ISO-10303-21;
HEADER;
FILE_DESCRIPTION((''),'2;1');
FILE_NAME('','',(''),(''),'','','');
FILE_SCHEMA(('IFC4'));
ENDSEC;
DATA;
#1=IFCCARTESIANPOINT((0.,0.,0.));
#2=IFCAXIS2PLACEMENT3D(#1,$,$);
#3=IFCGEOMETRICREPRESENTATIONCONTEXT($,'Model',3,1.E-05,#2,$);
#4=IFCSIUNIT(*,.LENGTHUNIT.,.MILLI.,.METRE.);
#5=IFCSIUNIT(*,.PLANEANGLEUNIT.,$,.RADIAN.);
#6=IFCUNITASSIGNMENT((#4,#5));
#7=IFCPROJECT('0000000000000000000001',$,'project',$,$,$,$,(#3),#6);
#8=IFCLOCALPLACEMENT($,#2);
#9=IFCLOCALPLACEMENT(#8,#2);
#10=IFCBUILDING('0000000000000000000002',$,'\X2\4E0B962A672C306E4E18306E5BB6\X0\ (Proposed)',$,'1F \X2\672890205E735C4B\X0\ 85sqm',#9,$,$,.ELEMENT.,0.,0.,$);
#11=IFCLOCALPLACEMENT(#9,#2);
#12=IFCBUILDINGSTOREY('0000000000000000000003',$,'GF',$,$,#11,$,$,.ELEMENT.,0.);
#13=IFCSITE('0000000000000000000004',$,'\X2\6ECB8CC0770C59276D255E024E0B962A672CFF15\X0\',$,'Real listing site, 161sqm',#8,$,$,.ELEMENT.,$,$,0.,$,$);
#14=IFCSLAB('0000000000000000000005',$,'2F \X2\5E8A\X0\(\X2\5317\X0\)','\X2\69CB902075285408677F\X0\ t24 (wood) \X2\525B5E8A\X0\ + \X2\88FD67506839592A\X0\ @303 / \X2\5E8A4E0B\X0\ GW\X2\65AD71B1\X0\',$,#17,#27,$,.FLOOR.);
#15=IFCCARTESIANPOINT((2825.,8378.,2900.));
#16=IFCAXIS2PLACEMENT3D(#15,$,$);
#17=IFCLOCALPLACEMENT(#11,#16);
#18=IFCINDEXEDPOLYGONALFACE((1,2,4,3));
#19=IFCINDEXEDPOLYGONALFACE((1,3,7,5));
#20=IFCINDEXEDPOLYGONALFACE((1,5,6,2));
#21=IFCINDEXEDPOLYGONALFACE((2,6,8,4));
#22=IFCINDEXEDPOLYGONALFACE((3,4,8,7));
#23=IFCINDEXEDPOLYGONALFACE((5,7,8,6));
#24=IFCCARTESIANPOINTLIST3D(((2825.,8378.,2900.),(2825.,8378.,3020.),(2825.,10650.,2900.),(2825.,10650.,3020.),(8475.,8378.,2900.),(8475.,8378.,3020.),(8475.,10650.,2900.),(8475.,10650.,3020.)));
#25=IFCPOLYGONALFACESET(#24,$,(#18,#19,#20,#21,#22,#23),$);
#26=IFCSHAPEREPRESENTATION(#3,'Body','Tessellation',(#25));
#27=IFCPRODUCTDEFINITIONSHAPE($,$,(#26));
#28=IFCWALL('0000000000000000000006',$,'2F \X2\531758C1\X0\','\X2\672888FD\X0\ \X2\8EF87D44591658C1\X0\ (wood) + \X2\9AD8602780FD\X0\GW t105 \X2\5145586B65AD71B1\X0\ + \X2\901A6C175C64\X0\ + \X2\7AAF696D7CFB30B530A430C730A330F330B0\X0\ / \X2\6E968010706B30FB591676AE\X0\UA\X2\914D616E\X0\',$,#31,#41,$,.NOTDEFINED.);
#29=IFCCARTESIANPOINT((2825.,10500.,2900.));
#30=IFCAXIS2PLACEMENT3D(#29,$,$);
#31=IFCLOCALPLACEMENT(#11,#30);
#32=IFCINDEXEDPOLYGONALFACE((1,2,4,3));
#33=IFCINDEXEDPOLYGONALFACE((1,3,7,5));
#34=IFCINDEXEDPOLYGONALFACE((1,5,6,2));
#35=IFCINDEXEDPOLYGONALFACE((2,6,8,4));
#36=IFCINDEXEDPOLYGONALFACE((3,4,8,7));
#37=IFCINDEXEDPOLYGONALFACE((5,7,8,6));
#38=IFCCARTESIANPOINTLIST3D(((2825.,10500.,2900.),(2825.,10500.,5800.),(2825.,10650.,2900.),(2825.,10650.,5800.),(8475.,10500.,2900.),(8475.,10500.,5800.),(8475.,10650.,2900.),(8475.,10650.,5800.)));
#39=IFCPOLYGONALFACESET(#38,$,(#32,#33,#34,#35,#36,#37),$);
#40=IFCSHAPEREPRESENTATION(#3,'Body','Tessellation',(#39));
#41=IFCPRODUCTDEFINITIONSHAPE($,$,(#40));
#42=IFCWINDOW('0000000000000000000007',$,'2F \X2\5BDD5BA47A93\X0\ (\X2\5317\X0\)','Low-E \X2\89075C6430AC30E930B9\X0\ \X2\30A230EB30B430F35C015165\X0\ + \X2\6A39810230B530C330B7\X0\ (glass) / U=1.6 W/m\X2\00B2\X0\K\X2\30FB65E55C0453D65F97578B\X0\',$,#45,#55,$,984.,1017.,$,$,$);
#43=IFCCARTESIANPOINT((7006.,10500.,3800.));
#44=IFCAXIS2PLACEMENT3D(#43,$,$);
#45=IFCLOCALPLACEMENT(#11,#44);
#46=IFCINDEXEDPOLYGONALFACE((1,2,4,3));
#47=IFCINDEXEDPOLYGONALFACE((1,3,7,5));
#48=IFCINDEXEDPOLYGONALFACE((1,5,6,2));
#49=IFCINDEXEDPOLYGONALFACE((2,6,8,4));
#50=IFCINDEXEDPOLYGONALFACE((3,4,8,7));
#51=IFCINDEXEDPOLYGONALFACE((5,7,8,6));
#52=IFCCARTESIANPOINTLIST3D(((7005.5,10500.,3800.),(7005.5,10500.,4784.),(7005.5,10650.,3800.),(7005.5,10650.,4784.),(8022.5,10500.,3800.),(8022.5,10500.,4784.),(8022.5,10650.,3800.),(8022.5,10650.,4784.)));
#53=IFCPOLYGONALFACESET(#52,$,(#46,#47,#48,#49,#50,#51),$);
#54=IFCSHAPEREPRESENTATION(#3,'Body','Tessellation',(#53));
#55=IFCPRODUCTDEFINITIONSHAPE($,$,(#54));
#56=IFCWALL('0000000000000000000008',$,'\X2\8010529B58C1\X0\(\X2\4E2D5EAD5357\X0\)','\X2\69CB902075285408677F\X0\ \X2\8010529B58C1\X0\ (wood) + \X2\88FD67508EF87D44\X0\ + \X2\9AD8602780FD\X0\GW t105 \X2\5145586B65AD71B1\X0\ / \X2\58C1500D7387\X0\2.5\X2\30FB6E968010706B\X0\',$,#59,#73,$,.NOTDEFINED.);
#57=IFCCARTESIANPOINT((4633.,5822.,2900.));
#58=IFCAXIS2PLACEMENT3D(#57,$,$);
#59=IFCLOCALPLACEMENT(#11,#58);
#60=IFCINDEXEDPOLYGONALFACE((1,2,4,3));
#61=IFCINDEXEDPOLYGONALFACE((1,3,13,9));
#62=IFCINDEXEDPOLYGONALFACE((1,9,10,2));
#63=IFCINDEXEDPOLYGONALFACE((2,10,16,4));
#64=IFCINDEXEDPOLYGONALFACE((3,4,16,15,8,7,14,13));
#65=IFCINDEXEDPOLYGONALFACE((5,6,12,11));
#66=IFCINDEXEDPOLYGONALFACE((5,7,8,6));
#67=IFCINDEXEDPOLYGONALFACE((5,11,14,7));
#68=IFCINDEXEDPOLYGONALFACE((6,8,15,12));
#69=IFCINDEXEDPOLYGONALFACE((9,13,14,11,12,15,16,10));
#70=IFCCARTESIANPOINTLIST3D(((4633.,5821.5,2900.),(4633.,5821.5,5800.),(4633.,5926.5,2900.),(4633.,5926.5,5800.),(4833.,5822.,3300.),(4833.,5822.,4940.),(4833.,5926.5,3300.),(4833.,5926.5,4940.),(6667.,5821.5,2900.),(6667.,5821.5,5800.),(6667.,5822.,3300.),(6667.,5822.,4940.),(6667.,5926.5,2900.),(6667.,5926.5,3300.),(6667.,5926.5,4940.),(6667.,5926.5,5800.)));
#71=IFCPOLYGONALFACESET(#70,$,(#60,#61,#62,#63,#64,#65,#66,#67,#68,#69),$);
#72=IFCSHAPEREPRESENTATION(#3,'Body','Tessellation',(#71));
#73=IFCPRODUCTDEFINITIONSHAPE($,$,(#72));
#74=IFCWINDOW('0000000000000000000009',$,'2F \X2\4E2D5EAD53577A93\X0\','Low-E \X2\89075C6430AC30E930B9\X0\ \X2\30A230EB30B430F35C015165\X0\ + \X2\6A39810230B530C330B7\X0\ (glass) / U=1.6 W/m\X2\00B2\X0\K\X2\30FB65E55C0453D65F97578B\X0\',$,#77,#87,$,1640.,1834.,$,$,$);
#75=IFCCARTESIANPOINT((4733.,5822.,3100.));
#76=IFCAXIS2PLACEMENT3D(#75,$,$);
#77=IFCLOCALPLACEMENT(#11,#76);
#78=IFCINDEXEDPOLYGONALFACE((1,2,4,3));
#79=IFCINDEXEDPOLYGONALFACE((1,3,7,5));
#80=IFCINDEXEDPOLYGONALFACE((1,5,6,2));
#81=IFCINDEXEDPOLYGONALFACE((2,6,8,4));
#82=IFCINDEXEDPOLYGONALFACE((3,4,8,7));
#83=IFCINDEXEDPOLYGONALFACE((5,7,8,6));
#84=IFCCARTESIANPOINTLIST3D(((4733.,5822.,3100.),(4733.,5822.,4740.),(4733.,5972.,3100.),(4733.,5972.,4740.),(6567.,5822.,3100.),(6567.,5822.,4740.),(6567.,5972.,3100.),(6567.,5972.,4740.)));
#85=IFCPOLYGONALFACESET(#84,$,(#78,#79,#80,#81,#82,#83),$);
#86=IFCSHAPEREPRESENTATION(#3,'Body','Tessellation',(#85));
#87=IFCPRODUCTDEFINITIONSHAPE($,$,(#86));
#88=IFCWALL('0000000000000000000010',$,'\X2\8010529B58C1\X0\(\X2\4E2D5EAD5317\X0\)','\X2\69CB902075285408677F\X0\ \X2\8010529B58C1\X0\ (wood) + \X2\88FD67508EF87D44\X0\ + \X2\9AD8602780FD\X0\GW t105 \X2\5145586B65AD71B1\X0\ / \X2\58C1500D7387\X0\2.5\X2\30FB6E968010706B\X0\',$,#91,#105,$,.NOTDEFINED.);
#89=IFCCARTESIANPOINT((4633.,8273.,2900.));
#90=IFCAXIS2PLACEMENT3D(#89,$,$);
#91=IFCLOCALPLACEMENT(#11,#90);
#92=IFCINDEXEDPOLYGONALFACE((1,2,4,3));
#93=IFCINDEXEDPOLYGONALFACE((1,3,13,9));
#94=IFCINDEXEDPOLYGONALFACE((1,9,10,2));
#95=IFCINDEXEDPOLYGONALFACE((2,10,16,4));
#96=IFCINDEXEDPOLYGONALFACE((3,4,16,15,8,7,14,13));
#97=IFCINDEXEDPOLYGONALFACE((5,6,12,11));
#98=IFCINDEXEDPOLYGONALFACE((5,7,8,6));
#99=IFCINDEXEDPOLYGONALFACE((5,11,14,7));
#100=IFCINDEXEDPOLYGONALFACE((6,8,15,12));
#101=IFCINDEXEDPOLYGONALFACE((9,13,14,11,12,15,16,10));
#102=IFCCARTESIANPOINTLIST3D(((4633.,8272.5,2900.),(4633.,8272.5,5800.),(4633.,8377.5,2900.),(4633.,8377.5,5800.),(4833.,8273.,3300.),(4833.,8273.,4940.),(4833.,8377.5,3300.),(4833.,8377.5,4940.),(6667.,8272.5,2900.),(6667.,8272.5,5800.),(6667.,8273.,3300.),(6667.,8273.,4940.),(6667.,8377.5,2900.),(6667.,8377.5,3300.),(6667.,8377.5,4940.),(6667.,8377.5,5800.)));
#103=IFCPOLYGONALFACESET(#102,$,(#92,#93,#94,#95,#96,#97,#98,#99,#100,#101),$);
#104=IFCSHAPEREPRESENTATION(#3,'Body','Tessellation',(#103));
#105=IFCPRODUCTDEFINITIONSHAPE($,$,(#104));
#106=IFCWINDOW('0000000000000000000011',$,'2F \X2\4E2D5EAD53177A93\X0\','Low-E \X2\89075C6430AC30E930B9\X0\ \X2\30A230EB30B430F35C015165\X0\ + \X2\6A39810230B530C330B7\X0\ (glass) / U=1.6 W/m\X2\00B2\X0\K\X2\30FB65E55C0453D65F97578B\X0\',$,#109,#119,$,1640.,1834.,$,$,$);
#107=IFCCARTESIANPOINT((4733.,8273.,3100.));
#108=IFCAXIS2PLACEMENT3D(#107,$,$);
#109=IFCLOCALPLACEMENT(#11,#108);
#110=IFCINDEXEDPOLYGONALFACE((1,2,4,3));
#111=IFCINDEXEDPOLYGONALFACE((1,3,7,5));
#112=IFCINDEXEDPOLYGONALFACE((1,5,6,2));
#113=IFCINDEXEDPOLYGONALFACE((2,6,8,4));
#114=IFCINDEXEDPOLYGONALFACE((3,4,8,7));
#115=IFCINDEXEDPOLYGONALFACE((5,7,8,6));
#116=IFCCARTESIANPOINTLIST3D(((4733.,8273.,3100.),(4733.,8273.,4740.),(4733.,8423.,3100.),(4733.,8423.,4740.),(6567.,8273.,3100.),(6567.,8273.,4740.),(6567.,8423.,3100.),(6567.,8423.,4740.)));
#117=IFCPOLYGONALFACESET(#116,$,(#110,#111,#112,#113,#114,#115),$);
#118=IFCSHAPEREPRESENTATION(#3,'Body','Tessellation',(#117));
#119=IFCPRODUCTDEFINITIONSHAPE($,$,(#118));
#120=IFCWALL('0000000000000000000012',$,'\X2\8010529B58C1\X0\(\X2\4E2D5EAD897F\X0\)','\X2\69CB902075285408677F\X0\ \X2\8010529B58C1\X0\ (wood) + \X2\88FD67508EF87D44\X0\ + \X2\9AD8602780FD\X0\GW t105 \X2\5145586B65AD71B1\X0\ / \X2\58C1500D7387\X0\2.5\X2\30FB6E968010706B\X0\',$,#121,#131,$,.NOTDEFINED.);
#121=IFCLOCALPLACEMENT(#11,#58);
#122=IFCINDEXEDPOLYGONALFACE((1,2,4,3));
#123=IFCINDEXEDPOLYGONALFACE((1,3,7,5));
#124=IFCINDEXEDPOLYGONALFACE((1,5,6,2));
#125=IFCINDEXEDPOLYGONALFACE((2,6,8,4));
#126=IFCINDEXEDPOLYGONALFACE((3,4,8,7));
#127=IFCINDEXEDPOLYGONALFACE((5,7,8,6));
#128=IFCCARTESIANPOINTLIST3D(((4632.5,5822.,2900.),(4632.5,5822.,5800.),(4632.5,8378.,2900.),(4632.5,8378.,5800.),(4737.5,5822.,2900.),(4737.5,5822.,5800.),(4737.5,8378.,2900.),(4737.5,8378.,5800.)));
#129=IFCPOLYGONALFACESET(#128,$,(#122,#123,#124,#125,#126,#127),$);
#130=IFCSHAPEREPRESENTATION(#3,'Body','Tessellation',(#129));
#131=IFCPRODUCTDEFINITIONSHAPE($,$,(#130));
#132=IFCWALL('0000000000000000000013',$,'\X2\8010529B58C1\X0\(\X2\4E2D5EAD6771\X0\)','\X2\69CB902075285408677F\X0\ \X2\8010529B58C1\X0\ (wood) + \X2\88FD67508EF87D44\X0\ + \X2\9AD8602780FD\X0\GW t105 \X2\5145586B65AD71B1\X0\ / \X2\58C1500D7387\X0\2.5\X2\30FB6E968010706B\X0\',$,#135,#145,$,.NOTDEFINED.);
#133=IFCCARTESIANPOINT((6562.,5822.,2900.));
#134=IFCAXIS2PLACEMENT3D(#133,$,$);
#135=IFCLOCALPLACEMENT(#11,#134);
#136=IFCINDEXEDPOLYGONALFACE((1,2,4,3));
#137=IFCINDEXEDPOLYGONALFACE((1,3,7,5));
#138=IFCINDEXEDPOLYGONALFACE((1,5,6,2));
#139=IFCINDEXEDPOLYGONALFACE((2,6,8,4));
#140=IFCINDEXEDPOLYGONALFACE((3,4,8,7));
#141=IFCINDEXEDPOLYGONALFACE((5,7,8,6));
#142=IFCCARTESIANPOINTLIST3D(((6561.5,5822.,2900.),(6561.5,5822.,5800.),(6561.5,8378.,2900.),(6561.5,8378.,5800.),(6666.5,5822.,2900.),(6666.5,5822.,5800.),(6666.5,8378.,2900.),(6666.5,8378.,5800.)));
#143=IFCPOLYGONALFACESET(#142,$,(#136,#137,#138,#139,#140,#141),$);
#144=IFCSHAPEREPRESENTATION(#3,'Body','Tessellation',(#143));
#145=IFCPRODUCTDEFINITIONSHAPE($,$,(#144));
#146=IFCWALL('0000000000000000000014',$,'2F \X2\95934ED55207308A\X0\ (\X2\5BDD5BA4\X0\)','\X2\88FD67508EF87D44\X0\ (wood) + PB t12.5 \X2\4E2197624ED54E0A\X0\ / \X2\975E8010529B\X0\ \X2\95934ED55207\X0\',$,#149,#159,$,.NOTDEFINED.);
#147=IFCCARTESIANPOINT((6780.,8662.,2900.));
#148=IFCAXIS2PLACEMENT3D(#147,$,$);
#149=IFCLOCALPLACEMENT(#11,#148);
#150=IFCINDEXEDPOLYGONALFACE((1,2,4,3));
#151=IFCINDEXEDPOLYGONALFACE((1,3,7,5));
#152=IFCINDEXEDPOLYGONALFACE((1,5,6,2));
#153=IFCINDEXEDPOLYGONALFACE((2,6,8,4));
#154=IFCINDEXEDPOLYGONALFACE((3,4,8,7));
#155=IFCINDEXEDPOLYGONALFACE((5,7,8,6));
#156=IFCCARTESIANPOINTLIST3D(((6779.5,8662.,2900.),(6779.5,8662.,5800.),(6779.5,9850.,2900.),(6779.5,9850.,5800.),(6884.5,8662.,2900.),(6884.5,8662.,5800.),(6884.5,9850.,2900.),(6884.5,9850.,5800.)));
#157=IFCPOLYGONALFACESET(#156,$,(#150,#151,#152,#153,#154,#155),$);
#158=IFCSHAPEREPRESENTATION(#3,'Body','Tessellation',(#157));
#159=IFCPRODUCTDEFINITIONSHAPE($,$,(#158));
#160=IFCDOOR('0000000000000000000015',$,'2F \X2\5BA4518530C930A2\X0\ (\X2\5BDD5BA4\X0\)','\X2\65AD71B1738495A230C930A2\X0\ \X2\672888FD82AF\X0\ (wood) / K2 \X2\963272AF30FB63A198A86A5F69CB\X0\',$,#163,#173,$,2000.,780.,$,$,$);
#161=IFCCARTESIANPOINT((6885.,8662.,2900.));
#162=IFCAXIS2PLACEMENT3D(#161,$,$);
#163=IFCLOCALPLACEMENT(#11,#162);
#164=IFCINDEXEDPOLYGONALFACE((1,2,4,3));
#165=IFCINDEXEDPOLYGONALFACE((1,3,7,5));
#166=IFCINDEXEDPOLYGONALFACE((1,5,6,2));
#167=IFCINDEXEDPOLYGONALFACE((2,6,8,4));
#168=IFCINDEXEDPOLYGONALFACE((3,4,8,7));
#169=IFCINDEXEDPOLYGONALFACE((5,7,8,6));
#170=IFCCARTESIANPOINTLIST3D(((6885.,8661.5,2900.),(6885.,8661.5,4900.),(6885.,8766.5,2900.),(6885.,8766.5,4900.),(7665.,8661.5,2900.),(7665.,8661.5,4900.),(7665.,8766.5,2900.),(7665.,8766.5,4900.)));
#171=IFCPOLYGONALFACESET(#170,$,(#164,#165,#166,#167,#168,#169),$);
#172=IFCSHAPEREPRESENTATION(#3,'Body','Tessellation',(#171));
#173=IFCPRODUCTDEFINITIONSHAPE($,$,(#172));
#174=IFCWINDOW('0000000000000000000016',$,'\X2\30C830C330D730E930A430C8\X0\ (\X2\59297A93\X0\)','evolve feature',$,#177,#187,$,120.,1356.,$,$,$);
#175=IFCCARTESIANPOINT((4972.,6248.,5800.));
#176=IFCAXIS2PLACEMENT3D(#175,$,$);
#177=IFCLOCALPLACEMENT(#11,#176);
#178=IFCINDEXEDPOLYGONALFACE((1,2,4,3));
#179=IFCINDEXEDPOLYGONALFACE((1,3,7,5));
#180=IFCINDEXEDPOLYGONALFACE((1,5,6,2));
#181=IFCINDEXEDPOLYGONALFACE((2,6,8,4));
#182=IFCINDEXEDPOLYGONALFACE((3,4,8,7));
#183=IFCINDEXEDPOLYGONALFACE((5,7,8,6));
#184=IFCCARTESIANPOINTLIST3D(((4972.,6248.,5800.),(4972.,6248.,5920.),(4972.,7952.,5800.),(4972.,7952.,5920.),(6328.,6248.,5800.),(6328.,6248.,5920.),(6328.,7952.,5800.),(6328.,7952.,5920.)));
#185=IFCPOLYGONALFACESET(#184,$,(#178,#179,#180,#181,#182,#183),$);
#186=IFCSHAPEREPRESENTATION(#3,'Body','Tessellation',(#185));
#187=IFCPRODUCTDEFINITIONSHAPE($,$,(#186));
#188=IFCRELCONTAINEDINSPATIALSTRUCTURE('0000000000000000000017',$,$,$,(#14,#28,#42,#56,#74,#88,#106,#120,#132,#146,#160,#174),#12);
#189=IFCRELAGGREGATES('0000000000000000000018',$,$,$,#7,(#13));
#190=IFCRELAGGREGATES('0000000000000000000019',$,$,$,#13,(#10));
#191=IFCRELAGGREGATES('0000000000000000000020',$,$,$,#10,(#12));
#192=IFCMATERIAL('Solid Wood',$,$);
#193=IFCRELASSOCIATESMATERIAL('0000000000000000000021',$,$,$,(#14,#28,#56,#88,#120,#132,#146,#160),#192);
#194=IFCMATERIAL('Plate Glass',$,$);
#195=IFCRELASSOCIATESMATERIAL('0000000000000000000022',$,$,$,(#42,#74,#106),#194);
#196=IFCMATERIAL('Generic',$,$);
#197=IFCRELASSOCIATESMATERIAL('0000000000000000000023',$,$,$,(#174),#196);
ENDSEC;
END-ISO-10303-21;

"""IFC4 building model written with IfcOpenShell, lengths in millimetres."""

from ifc_helpers import new_model, si_unit, frame, frame_2d, origin, place, context, project, spatial, rectangle, extrude, material, element, fill, save


model = new_model("IFC4")

# Units and contexts
model_context = context("Model", 3, precision=1e-05, world=origin())
ifc_project = project(units=[si_unit("LENGTHUNIT", "METRE", prefix="MILLI"), si_unit("PLANEANGLEUNIT", "RADIAN")], contexts=[model_context])

# Site, building, storey
site_placement = place(None, origin())
site = spatial("IfcSite", under=ifc_project, at=site_placement, Name="滋賀県大津市下阪本５", ObjectType="Real listing site, 161sqm", CompositionType="ELEMENT", RefElevation=0.0)
building_placement = place(site_placement, origin())
building = spatial("IfcBuilding", under=site, at=building_placement, Name="下阪本の丘の家 (Proposed)", ObjectType="1F 木造平屋 85sqm", CompositionType="ELEMENT", ElevationOfRefHeight=0.0, ElevationOfTerrain=0.0)
storey_placement = place(building_placement, origin())
storey = spatial("IfcBuildingStorey", under=building, at=storey_placement, Name="GF", CompositionType="ELEMENT", Elevation=0.0)

# Slab
ifc_material_1 = material(Name="Solid Wood")
slab_placement = place(storey_placement, frame((2825.0, 8378.0, 2900.0)))
element("IfcSlab", 1, at=slab_placement, inside=storey, material=ifc_material_1, Name="2F 床(北)", Description="構造用合板 t24 (wood) 剛床 + 製材根太 @303 / 床下 GW断熱", PredefinedType="FLOOR", context=model_context, shape_type="SweptSolid", body=[
    extrude(rectangle(XDim=5650.0, YDim=2272.0, at=frame_2d((2825.0, 1136.0))), frame((2825.0, 8378.0, 2900.0)), (0.0, 0.0, 1.0), 120.0),
])

# Walls, openings, windows
wall_1_placement = place(storey_placement, frame((2825.0, 10500.0, 2900.0)))
wall_1 = element("IfcWall", 2, at=wall_1_placement, inside=storey, material=ifc_material_1, Name="2F 北壁", Description="木製 軸組外壁 (wood) + 高性能GW t105 充填断熱 + 通気層 + 窯業系サイディング / 準耐火・外皮UA配慮", PredefinedType="NOTDEFINED", context=model_context, shape_type="SweptSolid", body=[
    extrude(rectangle(XDim=5650.0, YDim=150.0, at=frame_2d((2825.0, 75.0))), frame((2825.0, 10500.0, 2900.0)), (0.0, 0.0, 1.0), 2900.0),
])
opening_1_placement = place(storey_placement, frame((7006.0, 10500.0, 3800.0)))
opening_1 = element("IfcOpeningElement", 3, at=opening_1_placement, cuts=wall_1, PredefinedType="NOTDEFINED", context=model_context, shape_type="SweptSolid", body=[
    extrude(rectangle(XDim=1017.0, YDim=150.0, at=frame_2d((508.0, 75.0))), frame((7006.0, 10500.0, 3800.0)), (0.0, 0.0, 1.0), 984.0),
])
ifc_material_2 = material(Name="Plate Glass")
window_1_placement = place(storey_placement, frame((7006.0, 10500.0, 3800.0)))
window_1 = element("IfcWindow", 4, at=window_1_placement, inside=storey, material=ifc_material_2, Name="2F 寝室窓 (北)", Description="Low-E 複層ガラス アルゴン封入 + 樹脂サッシ (glass) / U=1.6 W/m²K・日射取得型", OverallHeight=984.0, OverallWidth=1017.0, context=model_context, shape_type="SweptSolid", body=[
    extrude(rectangle(XDim=1017.0, YDim=150.0, at=frame_2d((508.0, 75.0))), frame((7006.0, 10500.0, 3800.0)), (0.0, 0.0, 1.0), 984.0),
])
fill(opening_1, window_1)
wall_2_placement = place(storey_placement, frame((4633.0, 5822.0, 2900.0)))
wall_2 = element("IfcWall", 5, at=wall_2_placement, inside=storey, material=ifc_material_1, Name="耐力壁(中庭南)", Description="構造用合板 耐力壁 (wood) + 製材軸組 + 高性能GW t105 充填断熱 / 壁倍率2.5・準耐火", PredefinedType="NOTDEFINED", context=model_context, shape_type="SweptSolid", body=[
    extrude(rectangle(XDim=2034.0, YDim=105.0, at=frame_2d((1017.0, 52.0))), frame((4633.0, 5822.0, 2900.0)), (0.0, 0.0, 1.0), 2900.0),
])
opening_2_placement = place(storey_placement, frame((4733.0, 5822.0, 3100.0)))
opening_2 = element("IfcOpeningElement", 6, at=opening_2_placement, cuts=wall_2, PredefinedType="NOTDEFINED", context=model_context, shape_type="SweptSolid", body=[
    extrude(rectangle(XDim=1834.0, YDim=150.0, at=frame_2d((917.0, 75.0))), frame((4733.0, 5822.0, 3100.0)), (0.0, 0.0, 1.0), 1640.0),
])
window_2_placement = place(storey_placement, frame((4733.0, 5822.0, 3100.0)))
window_2 = element("IfcWindow", 7, at=window_2_placement, inside=storey, material=ifc_material_2, Name="2F 中庭南窓", Description="Low-E 複層ガラス アルゴン封入 + 樹脂サッシ (glass) / U=1.6 W/m²K・日射取得型", OverallHeight=1640.0, OverallWidth=1834.0, context=model_context, shape_type="SweptSolid", body=[
    extrude(rectangle(XDim=1834.0, YDim=150.0, at=frame_2d((917.0, 75.0))), frame((4733.0, 5822.0, 3100.0)), (0.0, 0.0, 1.0), 1640.0),
])
fill(opening_2, window_2)
wall_3_placement = place(storey_placement, frame((4633.0, 8273.0, 2900.0)))
wall_3 = element("IfcWall", 8, at=wall_3_placement, inside=storey, material=ifc_material_1, Name="耐力壁(中庭北)", Description="構造用合板 耐力壁 (wood) + 製材軸組 + 高性能GW t105 充填断熱 / 壁倍率2.5・準耐火", PredefinedType="NOTDEFINED", context=model_context, shape_type="SweptSolid", body=[
    extrude(rectangle(XDim=2034.0, YDim=105.0, at=frame_2d((1017.0, 52.0))), frame((4633.0, 8273.0, 2900.0)), (0.0, 0.0, 1.0), 2900.0),
])
opening_3_placement = place(storey_placement, frame((4733.0, 8273.0, 3100.0)))
opening_3 = element("IfcOpeningElement", 9, at=opening_3_placement, cuts=wall_3, PredefinedType="NOTDEFINED", context=model_context, shape_type="SweptSolid", body=[
    extrude(rectangle(XDim=1834.0, YDim=150.0, at=frame_2d((917.0, 75.0))), frame((4733.0, 8273.0, 3100.0)), (0.0, 0.0, 1.0), 1640.0),
])
window_3_placement = place(storey_placement, frame((4733.0, 8273.0, 3100.0)))
window_3 = element("IfcWindow", 10, at=window_3_placement, inside=storey, material=ifc_material_2, Name="2F 中庭北窓", Description="Low-E 複層ガラス アルゴン封入 + 樹脂サッシ (glass) / U=1.6 W/m²K・日射取得型", OverallHeight=1640.0, OverallWidth=1834.0, context=model_context, shape_type="SweptSolid", body=[
    extrude(rectangle(XDim=1834.0, YDim=150.0, at=frame_2d((917.0, 75.0))), frame((4733.0, 8273.0, 3100.0)), (0.0, 0.0, 1.0), 1640.0),
])
fill(opening_3, window_3)

# Walls
wall_4_placement = place(storey_placement, frame((4633.0, 5822.0, 2900.0)))
element("IfcWall", 11, at=wall_4_placement, inside=storey, material=ifc_material_1, Name="耐力壁(中庭西)", Description="構造用合板 耐力壁 (wood) + 製材軸組 + 高性能GW t105 充填断熱 / 壁倍率2.5・準耐火", PredefinedType="NOTDEFINED", context=model_context, shape_type="SweptSolid", body=[
    extrude(rectangle(XDim=105.0, YDim=2556.0, at=frame_2d((52.0, 1278.0))), frame((4633.0, 5822.0, 2900.0)), (0.0, 0.0, 1.0), 2900.0),
])
wall_5_placement = place(storey_placement, frame((6562.0, 5822.0, 2900.0)))
element("IfcWall", 12, at=wall_5_placement, inside=storey, material=ifc_material_1, Name="耐力壁(中庭東)", Description="構造用合板 耐力壁 (wood) + 製材軸組 + 高性能GW t105 充填断熱 / 壁倍率2.5・準耐火", PredefinedType="NOTDEFINED", context=model_context, shape_type="SweptSolid", body=[
    extrude(rectangle(XDim=105.0, YDim=2556.0, at=frame_2d((52.0, 1278.0))), frame((6562.0, 5822.0, 2900.0)), (0.0, 0.0, 1.0), 2900.0),
])
wall_6_placement = place(storey_placement, frame((6780.0, 8662.0, 2900.0)))
element("IfcWall", 13, at=wall_6_placement, inside=storey, material=ifc_material_1, Name="2F 間仕切り (寝室)", Description="製材軸組 (wood) + PB t12.5 両面仕上 / 非耐力 間仕切", PredefinedType="NOTDEFINED", context=model_context, shape_type="SweptSolid", body=[
    extrude(rectangle(XDim=105.0, YDim=1188.0, at=frame_2d((52.0, 594.0))), frame((6780.0, 8662.0, 2900.0)), (0.0, 0.0, 1.0), 2900.0),
])

# Door
door_placement = place(storey_placement, frame((6885.0, 8662.0, 2900.0)))
element("IfcDoor", 14, at=door_placement, inside=storey, material=ifc_material_1, Name="2F 室内ドア (寝室)", Description="断熱玄関ドア 木製芯 (wood) / K2 防犯・採風機構", OverallHeight=2000.0, OverallWidth=780.0, context=model_context, shape_type="SweptSolid", body=[
    extrude(rectangle(XDim=780.0, YDim=105.0, at=frame_2d((390.0, 52.0))), frame((6885.0, 8662.0, 2900.0)), (0.0, 0.0, 1.0), 2000.0),
])

# Window
ifc_material_3 = material(Name="Generic")
window_4_placement = place(storey_placement, frame((4972.0, 6248.0, 5800.0)))
element("IfcWindow", 15, at=window_4_placement, inside=storey, material=ifc_material_3, Name="トップライト (天窓)", Description="evolve feature", OverallHeight=120.0, OverallWidth=1356.0, context=model_context, shape_type="SweptSolid", body=[
    extrude(rectangle(XDim=1356.0, YDim=1704.0, at=frame_2d((678.0, 852.0))), frame((4972.0, 6248.0, 5800.0)), (0.0, 0.0, 1.0), 120.0),
])

save(model, "model.ifc")
